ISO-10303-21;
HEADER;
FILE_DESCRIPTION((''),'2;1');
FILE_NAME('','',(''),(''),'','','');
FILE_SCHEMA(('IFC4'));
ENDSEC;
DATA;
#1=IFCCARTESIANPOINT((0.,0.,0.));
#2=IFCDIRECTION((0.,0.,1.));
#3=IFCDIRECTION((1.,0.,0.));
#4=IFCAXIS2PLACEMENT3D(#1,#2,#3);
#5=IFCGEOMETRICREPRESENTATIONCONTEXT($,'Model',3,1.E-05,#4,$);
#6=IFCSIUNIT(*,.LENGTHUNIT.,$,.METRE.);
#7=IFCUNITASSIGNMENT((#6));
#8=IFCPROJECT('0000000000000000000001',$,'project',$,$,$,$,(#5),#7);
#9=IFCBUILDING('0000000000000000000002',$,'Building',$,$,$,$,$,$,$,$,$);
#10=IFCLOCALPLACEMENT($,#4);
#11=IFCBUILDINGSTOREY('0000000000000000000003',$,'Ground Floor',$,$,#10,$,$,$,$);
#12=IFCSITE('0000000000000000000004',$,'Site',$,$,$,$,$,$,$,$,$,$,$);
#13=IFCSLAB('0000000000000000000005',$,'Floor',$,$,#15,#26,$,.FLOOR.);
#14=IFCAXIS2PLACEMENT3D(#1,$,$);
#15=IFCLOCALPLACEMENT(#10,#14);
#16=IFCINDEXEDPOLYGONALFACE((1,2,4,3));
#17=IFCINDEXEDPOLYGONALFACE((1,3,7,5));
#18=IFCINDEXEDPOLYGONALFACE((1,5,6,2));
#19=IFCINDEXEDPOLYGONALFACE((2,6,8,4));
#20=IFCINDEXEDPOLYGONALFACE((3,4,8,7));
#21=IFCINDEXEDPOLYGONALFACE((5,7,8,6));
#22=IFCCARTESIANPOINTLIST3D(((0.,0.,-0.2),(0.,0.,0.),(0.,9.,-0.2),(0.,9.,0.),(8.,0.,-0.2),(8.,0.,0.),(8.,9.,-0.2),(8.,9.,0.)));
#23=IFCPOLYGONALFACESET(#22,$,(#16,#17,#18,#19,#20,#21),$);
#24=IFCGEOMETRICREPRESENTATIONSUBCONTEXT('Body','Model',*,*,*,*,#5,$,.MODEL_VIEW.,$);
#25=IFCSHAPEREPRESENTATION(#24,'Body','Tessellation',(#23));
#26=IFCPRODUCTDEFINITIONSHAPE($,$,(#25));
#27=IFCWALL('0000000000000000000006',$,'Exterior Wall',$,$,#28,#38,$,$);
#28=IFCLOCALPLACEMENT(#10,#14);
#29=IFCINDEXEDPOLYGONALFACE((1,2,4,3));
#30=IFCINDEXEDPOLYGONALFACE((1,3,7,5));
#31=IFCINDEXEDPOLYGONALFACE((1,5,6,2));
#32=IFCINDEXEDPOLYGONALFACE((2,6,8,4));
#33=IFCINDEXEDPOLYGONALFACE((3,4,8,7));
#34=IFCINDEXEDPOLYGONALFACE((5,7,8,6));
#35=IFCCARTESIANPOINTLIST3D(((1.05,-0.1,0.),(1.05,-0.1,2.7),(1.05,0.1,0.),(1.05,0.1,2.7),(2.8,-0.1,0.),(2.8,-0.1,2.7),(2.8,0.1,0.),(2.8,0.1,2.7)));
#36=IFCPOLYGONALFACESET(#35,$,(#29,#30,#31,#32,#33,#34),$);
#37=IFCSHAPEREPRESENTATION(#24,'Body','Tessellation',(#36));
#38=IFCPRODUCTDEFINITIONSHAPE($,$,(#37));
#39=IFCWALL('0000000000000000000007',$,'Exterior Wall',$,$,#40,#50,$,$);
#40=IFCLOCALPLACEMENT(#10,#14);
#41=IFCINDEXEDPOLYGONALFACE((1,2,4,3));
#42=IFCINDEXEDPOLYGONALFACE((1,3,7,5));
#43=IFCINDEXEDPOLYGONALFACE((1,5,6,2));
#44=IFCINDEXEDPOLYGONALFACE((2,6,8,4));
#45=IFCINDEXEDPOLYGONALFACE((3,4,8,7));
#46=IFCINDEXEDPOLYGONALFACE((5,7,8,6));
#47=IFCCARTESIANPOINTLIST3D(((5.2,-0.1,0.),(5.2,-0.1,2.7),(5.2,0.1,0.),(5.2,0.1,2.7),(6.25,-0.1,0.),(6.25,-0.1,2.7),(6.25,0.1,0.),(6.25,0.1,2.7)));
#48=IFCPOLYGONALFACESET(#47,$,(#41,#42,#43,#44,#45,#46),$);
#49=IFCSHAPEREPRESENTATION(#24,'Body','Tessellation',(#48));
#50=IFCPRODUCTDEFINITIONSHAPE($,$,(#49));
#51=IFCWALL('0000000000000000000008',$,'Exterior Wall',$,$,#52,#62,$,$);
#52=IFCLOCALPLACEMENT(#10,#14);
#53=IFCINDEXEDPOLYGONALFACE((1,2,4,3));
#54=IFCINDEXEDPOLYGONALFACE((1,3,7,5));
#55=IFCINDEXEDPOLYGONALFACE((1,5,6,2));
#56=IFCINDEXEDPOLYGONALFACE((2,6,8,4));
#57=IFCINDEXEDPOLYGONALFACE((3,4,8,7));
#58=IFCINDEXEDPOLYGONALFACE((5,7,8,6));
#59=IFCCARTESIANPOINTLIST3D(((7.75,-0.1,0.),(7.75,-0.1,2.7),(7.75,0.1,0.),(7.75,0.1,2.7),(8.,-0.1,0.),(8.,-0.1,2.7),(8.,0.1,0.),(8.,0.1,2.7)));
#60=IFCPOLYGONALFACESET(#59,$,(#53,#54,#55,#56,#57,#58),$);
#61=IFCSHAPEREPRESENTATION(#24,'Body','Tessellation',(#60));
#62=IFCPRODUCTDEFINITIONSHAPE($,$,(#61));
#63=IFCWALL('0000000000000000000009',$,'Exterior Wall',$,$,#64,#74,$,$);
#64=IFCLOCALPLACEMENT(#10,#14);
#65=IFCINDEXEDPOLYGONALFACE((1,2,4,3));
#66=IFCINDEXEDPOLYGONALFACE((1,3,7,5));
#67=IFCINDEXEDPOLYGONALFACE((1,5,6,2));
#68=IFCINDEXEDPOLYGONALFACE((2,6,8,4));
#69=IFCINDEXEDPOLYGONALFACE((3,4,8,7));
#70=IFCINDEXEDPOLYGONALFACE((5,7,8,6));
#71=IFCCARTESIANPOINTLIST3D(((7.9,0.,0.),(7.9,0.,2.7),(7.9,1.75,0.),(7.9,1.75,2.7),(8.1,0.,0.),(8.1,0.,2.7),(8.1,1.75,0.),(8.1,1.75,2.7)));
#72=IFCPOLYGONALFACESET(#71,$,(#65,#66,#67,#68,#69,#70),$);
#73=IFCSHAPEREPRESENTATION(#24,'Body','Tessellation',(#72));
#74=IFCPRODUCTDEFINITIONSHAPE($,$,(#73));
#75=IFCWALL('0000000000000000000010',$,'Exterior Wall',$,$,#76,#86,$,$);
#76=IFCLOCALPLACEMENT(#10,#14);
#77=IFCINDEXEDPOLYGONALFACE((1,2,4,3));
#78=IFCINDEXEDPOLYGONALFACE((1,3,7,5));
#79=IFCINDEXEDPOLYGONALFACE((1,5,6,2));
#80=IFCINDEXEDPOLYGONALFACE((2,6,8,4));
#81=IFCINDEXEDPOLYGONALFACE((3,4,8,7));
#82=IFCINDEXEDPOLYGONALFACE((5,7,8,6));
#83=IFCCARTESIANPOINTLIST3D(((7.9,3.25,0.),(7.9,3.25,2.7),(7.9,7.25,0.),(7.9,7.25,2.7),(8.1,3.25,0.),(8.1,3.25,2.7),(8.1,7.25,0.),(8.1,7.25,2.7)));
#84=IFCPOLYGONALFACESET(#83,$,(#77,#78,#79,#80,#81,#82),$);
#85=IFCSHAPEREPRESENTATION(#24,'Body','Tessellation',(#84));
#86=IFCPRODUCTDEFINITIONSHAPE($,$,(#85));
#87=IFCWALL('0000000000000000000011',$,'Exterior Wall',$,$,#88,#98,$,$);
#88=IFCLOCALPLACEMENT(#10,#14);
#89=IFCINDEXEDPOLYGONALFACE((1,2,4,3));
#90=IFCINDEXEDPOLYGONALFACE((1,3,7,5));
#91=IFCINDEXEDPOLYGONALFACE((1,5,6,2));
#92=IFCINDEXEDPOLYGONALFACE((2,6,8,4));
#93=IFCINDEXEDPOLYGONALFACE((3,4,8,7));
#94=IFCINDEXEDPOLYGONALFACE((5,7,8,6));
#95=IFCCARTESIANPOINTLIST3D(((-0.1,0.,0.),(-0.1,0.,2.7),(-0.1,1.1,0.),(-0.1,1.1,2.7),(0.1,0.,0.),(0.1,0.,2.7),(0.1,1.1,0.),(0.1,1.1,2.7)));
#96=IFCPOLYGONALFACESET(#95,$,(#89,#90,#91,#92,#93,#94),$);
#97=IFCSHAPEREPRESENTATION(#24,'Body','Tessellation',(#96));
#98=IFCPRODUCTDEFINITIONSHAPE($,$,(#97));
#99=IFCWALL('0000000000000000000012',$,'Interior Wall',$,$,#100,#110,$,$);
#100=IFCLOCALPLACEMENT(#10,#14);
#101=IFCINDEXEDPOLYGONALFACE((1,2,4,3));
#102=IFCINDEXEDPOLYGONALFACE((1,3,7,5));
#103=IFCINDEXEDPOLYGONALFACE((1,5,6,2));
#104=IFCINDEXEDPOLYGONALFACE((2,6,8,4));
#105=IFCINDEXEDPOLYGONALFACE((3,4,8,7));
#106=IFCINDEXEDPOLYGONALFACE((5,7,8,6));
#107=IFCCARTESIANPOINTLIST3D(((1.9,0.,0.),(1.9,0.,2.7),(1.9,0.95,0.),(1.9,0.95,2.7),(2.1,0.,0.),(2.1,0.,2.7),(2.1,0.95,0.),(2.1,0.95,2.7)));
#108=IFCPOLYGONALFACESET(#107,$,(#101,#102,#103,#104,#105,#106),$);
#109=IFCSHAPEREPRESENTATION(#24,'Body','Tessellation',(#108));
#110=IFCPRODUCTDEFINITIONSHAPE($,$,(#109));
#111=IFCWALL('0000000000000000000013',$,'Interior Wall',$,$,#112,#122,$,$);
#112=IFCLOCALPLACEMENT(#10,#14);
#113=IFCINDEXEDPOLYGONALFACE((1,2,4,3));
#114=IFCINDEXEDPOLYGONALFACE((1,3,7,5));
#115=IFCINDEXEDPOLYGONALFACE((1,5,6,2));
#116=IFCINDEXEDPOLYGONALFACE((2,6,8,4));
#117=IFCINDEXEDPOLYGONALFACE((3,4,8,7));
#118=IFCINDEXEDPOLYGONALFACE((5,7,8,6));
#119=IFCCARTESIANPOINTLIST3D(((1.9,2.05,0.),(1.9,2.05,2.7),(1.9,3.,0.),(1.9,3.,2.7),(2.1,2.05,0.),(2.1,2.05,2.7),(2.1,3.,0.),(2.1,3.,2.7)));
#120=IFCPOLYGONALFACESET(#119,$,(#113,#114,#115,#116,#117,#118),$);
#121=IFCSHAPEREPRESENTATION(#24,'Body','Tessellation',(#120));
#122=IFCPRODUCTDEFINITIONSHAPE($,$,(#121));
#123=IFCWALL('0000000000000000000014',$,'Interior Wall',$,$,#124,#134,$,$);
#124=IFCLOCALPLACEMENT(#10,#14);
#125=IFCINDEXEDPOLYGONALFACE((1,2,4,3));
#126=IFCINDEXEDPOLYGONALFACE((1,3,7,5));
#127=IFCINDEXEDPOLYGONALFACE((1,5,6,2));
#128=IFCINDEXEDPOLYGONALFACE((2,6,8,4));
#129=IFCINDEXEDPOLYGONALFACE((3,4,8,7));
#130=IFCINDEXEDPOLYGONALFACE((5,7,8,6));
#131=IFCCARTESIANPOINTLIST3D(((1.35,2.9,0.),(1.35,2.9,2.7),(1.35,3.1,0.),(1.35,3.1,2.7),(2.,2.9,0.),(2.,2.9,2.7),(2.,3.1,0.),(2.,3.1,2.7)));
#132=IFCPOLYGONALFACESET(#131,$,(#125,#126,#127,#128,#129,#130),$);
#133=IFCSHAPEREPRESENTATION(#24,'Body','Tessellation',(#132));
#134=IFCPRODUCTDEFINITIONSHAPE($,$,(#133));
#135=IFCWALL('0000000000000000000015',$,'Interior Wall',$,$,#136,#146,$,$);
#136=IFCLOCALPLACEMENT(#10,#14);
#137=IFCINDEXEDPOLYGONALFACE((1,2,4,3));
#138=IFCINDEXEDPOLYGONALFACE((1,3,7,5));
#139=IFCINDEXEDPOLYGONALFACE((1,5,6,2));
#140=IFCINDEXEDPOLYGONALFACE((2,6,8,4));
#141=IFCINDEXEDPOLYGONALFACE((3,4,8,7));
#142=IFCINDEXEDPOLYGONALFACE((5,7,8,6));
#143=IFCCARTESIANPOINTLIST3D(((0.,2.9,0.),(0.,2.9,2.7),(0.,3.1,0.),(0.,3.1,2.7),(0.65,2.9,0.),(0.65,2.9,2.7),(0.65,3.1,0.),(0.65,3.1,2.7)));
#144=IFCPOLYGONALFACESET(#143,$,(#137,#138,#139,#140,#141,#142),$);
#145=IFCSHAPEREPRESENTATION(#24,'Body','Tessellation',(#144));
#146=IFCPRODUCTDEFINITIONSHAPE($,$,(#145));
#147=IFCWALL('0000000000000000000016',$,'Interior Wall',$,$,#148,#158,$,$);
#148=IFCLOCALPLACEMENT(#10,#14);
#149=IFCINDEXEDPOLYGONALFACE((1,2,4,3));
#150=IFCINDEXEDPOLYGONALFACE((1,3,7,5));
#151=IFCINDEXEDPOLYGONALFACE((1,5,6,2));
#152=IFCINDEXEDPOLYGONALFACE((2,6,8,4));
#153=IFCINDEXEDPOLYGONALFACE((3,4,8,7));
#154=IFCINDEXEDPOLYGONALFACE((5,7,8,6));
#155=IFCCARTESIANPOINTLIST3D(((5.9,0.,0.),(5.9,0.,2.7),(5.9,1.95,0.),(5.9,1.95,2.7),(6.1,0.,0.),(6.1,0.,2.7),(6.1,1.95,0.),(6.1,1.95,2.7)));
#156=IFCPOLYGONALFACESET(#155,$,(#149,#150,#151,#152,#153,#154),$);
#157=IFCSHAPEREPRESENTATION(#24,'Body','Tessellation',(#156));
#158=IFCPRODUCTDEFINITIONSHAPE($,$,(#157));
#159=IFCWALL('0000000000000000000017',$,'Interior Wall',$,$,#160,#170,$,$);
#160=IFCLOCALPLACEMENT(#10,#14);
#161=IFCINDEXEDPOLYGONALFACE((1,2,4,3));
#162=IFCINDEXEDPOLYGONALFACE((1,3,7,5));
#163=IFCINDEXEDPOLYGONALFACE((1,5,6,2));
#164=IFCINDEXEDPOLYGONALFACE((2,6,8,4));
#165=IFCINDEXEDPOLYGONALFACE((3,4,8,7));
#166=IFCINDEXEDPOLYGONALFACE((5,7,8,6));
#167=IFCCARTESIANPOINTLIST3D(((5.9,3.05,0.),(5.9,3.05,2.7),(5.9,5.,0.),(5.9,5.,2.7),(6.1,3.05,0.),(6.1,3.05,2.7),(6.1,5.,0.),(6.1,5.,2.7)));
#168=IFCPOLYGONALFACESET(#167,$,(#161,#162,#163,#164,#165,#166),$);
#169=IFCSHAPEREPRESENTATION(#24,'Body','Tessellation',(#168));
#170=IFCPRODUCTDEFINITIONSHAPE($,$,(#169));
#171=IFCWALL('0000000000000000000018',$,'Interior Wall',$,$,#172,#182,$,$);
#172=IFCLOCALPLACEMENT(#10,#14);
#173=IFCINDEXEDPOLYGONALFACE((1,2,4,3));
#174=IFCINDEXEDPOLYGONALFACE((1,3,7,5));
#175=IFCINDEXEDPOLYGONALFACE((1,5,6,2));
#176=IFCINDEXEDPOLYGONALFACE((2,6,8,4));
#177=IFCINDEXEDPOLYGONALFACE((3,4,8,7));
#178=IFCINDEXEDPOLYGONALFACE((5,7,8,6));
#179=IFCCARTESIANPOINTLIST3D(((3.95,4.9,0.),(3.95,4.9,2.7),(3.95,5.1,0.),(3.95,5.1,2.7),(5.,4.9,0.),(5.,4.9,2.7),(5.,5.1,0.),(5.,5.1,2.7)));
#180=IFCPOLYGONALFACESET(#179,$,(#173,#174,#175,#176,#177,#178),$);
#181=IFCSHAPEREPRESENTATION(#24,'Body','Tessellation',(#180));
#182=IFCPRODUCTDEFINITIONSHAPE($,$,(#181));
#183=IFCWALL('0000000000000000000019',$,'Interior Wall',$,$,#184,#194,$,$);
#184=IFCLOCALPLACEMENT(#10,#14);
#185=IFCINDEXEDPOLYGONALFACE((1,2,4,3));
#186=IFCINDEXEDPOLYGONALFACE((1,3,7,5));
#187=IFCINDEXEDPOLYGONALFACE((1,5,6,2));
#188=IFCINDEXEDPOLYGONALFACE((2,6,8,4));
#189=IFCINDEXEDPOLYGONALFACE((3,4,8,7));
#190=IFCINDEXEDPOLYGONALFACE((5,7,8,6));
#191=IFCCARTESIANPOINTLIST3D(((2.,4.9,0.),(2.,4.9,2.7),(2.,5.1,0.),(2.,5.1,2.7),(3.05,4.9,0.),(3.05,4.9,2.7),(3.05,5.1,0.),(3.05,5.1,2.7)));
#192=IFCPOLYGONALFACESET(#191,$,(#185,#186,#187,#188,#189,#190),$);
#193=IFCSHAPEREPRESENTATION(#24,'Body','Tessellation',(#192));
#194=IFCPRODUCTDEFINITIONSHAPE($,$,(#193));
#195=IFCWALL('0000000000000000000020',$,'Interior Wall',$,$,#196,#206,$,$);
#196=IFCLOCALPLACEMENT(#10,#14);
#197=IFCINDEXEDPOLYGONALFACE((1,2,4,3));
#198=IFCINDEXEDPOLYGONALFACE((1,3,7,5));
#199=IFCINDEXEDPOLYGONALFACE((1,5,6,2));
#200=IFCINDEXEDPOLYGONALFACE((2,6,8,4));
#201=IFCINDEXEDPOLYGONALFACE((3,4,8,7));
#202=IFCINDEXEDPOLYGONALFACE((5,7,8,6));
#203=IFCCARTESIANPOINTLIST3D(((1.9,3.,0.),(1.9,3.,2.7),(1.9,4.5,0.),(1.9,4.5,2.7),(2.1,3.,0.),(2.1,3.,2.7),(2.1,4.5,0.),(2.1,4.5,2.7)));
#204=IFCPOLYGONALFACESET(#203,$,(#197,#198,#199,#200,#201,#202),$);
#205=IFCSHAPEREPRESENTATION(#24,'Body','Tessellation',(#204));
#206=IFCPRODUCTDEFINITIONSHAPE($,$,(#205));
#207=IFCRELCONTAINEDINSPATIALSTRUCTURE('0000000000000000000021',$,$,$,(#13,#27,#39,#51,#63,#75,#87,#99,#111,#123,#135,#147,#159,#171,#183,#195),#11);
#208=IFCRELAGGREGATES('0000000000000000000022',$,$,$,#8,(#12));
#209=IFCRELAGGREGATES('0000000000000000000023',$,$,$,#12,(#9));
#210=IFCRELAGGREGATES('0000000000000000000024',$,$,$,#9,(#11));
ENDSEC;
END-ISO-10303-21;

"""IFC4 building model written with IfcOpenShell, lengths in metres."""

from ifc_helpers import new_model, si_unit, frame, origin_with_axes, place, context, subcontext, project, spatial, indexed_curve, outline, extrude, element, save


model = new_model("IFC4")

# Units and contexts
model_context = context("Model", 3, precision=1e-05, world=origin_with_axes())
body_context = subcontext(model_context, "Body", "Model", "MODEL_VIEW")
ifc_project = project(units=[si_unit("LENGTHUNIT", "METRE")], contexts=[model_context])

# Site, building, storey
site = spatial("IfcSite", under=ifc_project, Name="Site")
building = spatial("IfcBuilding", under=site, Name="Building")
storey_placement = place(None, origin_with_axes())
storey = spatial("IfcBuildingStorey", under=building, at=storey_placement, Name="Ground Floor")

# Slab
slab_placement = place(storey_placement, frame((0.0, 0.0, -0.2), z_axis=(0.0, 0.0, 1.0), x_axis=(1.0, 0.0, 0.0)))
element("IfcSlab", 1, at=slab_placement, inside=storey, Name="Floor", PredefinedType="FLOOR", context=body_context, shape_type="SweptSolid", body=[
    extrude(outline(indexed_curve([(0.0, 0.0), (8.0, 0.0), (8.0, 9.0), (0.0, 9.0)])), None, (0.0, 0.0, 1.0), 0.2),
])

# Walls
wall_1_placement = place(storey_placement, frame((1.05, 0.0, 0.0), z_axis=(0.0, 0.0, 1.0), x_axis=(1.0, 0.0, 0.0)))
element("IfcWall", 2, at=wall_1_placement, inside=storey, Name="Exterior Wall", context=body_context, shape_type="SweptSolid", body=[
    extrude(outline(indexed_curve([(0.0, 0.0), (0.0, 0.2), (1.75, 0.2), (1.75, 0.0), (0.0, 0.0)], self_intersect=False)), frame((0.0, -0.1, 0.0), z_axis=(0.0, 0.0, 1.0), x_axis=(1.0, 0.0, 0.0)), (0.0, 0.0, 1.0), 2.7),
])
wall_2_placement = place(storey_placement, frame((5.2, 0.0, 0.0), z_axis=(0.0, 0.0, 1.0), x_axis=(1.0, 0.0, 0.0)))
element("IfcWall", 3, at=wall_2_placement, inside=storey, Name="Exterior Wall", context=body_context, shape_type="SweptSolid", body=[
    extrude(outline(indexed_curve([(0.0, 0.0), (0.0, 0.2), (1.05, 0.2), (1.05, 0.0), (0.0, 0.0)], self_intersect=False)), frame((0.0, -0.1, 0.0), z_axis=(0.0, 0.0, 1.0), x_axis=(1.0, 0.0, 0.0)), (0.0, 0.0, 1.0), 2.7),
])
wall_3_placement = place(storey_placement, frame((7.75, 0.0, 0.0), z_axis=(0.0, 0.0, 1.0), x_axis=(1.0, 0.0, 0.0)))
element("IfcWall", 4, at=wall_3_placement, inside=storey, Name="Exterior Wall", context=body_context, shape_type="SweptSolid", body=[
    extrude(outline(indexed_curve([(0.0, 0.0), (0.0, 0.2), (0.25, 0.2), (0.25, 0.0), (0.0, 0.0)], self_intersect=False)), frame((0.0, -0.1, 0.0), z_axis=(0.0, 0.0, 1.0), x_axis=(1.0, 0.0, 0.0)), (0.0, 0.0, 1.0), 2.7),
])
wall_4_placement = place(storey_placement, frame((8.0, 0.0, 0.0), z_axis=(0.0, 0.0, 1.0), x_axis=(0.0, 1.0, 0.0)))
element("IfcWall", 5, at=wall_4_placement, inside=storey, Name="Exterior Wall", context=body_context, shape_type="SweptSolid", body=[
    extrude(outline(indexed_curve([(0.0, 0.0), (0.0, 0.2), (1.75, 0.2), (1.75, 0.0), (0.0, 0.0)], self_intersect=False)), frame((0.0, -0.1, 0.0), z_axis=(0.0, 0.0, 1.0), x_axis=(1.0, 0.0, 0.0)), (0.0, 0.0, 1.0), 2.7),
])
wall_5_placement = place(storey_placement, frame((8.0, 3.25, 0.0), z_axis=(0.0, 0.0, 1.0), x_axis=(0.0, 1.0, 0.0)))
element("IfcWall", 6, at=wall_5_placement, inside=storey, Name="Exterior Wall", context=body_context, shape_type="SweptSolid", body=[
    extrude(outline(indexed_curve([(0.0, 0.0), (0.0, 0.2), (4.0, 0.2), (4.0, 0.0), (0.0, 0.0)], self_intersect=False)), frame((0.0, -0.1, 0.0), z_axis=(0.0, 0.0, 1.0), x_axis=(1.0, 0.0, 0.0)), (0.0, 0.0, 1.0), 2.7),
])
wall_6_placement = place(storey_placement, frame((0.0, 1.1, 0.0), z_axis=(0.0, 0.0, 1.0), x_axis=(0.0, -1.0, 0.0)))
element("IfcWall", 7, at=wall_6_placement, inside=storey, Name="Exterior Wall", context=body_context, shape_type="SweptSolid", body=[
    extrude(outline(indexed_curve([(0.0, 0.0), (0.0, 0.2), (1.1, 0.2), (1.1, 0.0), (0.0, 0.0)], self_intersect=False)), frame((0.0, -0.1, 0.0), z_axis=(0.0, 0.0, 1.0), x_axis=(1.0, 0.0, 0.0)), (0.0, 0.0, 1.0), 2.7),
])
wall_7_placement = place(storey_placement, frame((2.0, 0.0, 0.0), z_axis=(0.0, 0.0, 1.0), x_axis=(0.0, 1.0, 0.0)))
element("IfcWall", 8, at=wall_7_placement, inside=storey, Name="Interior Wall", context=body_context, shape_type="SweptSolid", body=[
    extrude(outline(indexed_curve([(0.0, 0.0), (0.0, 0.2), (0.95, 0.2), (0.95, 0.0), (0.0, 0.0)], self_intersect=False)), frame((0.0, -0.1, 0.0), z_axis=(0.0, 0.0, 1.0), x_axis=(1.0, 0.0, 0.0)), (0.0, 0.0, 1.0), 2.7),
])
wall_8_placement = place(storey_placement, frame((2.0, 2.05, 0.0), z_axis=(0.0, 0.0, 1.0), x_axis=(0.0, 1.0, 0.0)))
element("IfcWall", 9, at=wall_8_placement, inside=storey, Name="Interior Wall", context=body_context, shape_type="SweptSolid", body=[
    extrude(outline(indexed_curve([(0.0, 0.0), (0.0, 0.2), (0.95, 0.2), (0.95, 0.0), (0.0, 0.0)], self_intersect=False)), frame((0.0, -0.1, 0.0), z_axis=(0.0, 0.0, 1.0), x_axis=(1.0, 0.0, 0.0)), (0.0, 0.0, 1.0), 2.7),
])
for number, where, z_axis, x_axis, name in (
    (10, (2.0, 3.0, 0.0), (0.0, 0.0, 1.0), (-1.0, 0.0, 0.0), "Interior Wall"),
    (11, (0.65, 3.0, 0.0), (0.0, 0.0, 1.0), (-1.0, 0.0, 0.0), "Interior Wall"),
):
    element("IfcWall", number, at=place(storey_placement, frame(where, z_axis=z_axis, x_axis=x_axis)), inside=storey, Name=name, context=body_context, shape_type="SweptSolid", body=[
        extrude(outline(indexed_curve([(0.0, 0.0), (0.0, 0.2), (0.65, 0.2), (0.65, 0.0), (0.0, 0.0)], self_intersect=False)), frame((0.0, -0.1, 0.0), z_axis=(0.0, 0.0, 1.0), x_axis=(1.0, 0.0, 0.0)), (0.0, 0.0, 1.0), 2.7),
    ])
wall_9_placement = place(storey_placement, frame((6.0, 0.0, 0.0), z_axis=(0.0, 0.0, 1.0), x_axis=(0.0, 1.0, 0.0)))
element("IfcWall", 12, at=wall_9_placement, inside=storey, Name="Interior Wall", context=body_context, shape_type="SweptSolid", body=[
    extrude(outline(indexed_curve([(0.0, 0.0), (0.0, 0.2), (1.95, 0.2), (1.95, 0.0), (0.0, 0.0)], self_intersect=False)), frame((0.0, -0.1, 0.0), z_axis=(0.0, 0.0, 1.0), x_axis=(1.0, 0.0, 0.0)), (0.0, 0.0, 1.0), 2.7),
])
wall_10_placement = place(storey_placement, frame((6.0, 3.05, 0.0), z_axis=(0.0, 0.0, 1.0), x_axis=(0.0, 1.0, 0.0)))
element("IfcWall", 13, at=wall_10_placement, inside=storey, Name="Interior Wall", context=body_context, shape_type="SweptSolid", body=[
    extrude(outline(indexed_curve([(0.0, 0.0), (0.0, 0.2), (1.95, 0.2), (1.95, 0.0), (0.0, 0.0)], self_intersect=False)), frame((0.0, -0.1, 0.0), z_axis=(0.0, 0.0, 1.0), x_axis=(1.0, 0.0, 0.0)), (0.0, 0.0, 1.0), 2.7),
])
for number, where, z_axis, x_axis, name in (
    (14, (5.0, 5.0, 0.0), (0.0, 0.0, 1.0), (-1.0, 0.0, 0.0), "Interior Wall"),
    (15, (3.05, 5.0, 0.0), (0.0, 0.0, 1.0), (-1.0, 0.0, 0.0), "Interior Wall"),
):
    element("IfcWall", number, at=place(storey_placement, frame(where, z_axis=z_axis, x_axis=x_axis)), inside=storey, Name=name, context=body_context, shape_type="SweptSolid", body=[
        extrude(outline(indexed_curve([(0.0, 0.0), (0.0, 0.2), (1.05, 0.2), (1.05, 0.0), (0.0, 0.0)], self_intersect=False)), frame((0.0, -0.1, 0.0), z_axis=(0.0, 0.0, 1.0), x_axis=(1.0, 0.0, 0.0)), (0.0, 0.0, 1.0), 2.7),
    ])
wall_11_placement = place(storey_placement, frame((2.0, 4.5, 0.0), z_axis=(0.0, 0.0, 1.0), x_axis=(0.0, -1.0, 0.0)))
element("IfcWall", 16, at=wall_11_placement, inside=storey, Name="Interior Wall", context=body_context, shape_type="SweptSolid", body=[
    extrude(outline(indexed_curve([(0.0, 0.0), (0.0, 0.2), (1.5, 0.2), (1.5, 0.0), (0.0, 0.0)], self_intersect=False)), frame((0.0, -0.1, 0.0), z_axis=(0.0, 0.0, 1.0), x_axis=(1.0, 0.0, 0.0)), (0.0, 0.0, 1.0), 2.7),
])

save(model, "model.ifc")
